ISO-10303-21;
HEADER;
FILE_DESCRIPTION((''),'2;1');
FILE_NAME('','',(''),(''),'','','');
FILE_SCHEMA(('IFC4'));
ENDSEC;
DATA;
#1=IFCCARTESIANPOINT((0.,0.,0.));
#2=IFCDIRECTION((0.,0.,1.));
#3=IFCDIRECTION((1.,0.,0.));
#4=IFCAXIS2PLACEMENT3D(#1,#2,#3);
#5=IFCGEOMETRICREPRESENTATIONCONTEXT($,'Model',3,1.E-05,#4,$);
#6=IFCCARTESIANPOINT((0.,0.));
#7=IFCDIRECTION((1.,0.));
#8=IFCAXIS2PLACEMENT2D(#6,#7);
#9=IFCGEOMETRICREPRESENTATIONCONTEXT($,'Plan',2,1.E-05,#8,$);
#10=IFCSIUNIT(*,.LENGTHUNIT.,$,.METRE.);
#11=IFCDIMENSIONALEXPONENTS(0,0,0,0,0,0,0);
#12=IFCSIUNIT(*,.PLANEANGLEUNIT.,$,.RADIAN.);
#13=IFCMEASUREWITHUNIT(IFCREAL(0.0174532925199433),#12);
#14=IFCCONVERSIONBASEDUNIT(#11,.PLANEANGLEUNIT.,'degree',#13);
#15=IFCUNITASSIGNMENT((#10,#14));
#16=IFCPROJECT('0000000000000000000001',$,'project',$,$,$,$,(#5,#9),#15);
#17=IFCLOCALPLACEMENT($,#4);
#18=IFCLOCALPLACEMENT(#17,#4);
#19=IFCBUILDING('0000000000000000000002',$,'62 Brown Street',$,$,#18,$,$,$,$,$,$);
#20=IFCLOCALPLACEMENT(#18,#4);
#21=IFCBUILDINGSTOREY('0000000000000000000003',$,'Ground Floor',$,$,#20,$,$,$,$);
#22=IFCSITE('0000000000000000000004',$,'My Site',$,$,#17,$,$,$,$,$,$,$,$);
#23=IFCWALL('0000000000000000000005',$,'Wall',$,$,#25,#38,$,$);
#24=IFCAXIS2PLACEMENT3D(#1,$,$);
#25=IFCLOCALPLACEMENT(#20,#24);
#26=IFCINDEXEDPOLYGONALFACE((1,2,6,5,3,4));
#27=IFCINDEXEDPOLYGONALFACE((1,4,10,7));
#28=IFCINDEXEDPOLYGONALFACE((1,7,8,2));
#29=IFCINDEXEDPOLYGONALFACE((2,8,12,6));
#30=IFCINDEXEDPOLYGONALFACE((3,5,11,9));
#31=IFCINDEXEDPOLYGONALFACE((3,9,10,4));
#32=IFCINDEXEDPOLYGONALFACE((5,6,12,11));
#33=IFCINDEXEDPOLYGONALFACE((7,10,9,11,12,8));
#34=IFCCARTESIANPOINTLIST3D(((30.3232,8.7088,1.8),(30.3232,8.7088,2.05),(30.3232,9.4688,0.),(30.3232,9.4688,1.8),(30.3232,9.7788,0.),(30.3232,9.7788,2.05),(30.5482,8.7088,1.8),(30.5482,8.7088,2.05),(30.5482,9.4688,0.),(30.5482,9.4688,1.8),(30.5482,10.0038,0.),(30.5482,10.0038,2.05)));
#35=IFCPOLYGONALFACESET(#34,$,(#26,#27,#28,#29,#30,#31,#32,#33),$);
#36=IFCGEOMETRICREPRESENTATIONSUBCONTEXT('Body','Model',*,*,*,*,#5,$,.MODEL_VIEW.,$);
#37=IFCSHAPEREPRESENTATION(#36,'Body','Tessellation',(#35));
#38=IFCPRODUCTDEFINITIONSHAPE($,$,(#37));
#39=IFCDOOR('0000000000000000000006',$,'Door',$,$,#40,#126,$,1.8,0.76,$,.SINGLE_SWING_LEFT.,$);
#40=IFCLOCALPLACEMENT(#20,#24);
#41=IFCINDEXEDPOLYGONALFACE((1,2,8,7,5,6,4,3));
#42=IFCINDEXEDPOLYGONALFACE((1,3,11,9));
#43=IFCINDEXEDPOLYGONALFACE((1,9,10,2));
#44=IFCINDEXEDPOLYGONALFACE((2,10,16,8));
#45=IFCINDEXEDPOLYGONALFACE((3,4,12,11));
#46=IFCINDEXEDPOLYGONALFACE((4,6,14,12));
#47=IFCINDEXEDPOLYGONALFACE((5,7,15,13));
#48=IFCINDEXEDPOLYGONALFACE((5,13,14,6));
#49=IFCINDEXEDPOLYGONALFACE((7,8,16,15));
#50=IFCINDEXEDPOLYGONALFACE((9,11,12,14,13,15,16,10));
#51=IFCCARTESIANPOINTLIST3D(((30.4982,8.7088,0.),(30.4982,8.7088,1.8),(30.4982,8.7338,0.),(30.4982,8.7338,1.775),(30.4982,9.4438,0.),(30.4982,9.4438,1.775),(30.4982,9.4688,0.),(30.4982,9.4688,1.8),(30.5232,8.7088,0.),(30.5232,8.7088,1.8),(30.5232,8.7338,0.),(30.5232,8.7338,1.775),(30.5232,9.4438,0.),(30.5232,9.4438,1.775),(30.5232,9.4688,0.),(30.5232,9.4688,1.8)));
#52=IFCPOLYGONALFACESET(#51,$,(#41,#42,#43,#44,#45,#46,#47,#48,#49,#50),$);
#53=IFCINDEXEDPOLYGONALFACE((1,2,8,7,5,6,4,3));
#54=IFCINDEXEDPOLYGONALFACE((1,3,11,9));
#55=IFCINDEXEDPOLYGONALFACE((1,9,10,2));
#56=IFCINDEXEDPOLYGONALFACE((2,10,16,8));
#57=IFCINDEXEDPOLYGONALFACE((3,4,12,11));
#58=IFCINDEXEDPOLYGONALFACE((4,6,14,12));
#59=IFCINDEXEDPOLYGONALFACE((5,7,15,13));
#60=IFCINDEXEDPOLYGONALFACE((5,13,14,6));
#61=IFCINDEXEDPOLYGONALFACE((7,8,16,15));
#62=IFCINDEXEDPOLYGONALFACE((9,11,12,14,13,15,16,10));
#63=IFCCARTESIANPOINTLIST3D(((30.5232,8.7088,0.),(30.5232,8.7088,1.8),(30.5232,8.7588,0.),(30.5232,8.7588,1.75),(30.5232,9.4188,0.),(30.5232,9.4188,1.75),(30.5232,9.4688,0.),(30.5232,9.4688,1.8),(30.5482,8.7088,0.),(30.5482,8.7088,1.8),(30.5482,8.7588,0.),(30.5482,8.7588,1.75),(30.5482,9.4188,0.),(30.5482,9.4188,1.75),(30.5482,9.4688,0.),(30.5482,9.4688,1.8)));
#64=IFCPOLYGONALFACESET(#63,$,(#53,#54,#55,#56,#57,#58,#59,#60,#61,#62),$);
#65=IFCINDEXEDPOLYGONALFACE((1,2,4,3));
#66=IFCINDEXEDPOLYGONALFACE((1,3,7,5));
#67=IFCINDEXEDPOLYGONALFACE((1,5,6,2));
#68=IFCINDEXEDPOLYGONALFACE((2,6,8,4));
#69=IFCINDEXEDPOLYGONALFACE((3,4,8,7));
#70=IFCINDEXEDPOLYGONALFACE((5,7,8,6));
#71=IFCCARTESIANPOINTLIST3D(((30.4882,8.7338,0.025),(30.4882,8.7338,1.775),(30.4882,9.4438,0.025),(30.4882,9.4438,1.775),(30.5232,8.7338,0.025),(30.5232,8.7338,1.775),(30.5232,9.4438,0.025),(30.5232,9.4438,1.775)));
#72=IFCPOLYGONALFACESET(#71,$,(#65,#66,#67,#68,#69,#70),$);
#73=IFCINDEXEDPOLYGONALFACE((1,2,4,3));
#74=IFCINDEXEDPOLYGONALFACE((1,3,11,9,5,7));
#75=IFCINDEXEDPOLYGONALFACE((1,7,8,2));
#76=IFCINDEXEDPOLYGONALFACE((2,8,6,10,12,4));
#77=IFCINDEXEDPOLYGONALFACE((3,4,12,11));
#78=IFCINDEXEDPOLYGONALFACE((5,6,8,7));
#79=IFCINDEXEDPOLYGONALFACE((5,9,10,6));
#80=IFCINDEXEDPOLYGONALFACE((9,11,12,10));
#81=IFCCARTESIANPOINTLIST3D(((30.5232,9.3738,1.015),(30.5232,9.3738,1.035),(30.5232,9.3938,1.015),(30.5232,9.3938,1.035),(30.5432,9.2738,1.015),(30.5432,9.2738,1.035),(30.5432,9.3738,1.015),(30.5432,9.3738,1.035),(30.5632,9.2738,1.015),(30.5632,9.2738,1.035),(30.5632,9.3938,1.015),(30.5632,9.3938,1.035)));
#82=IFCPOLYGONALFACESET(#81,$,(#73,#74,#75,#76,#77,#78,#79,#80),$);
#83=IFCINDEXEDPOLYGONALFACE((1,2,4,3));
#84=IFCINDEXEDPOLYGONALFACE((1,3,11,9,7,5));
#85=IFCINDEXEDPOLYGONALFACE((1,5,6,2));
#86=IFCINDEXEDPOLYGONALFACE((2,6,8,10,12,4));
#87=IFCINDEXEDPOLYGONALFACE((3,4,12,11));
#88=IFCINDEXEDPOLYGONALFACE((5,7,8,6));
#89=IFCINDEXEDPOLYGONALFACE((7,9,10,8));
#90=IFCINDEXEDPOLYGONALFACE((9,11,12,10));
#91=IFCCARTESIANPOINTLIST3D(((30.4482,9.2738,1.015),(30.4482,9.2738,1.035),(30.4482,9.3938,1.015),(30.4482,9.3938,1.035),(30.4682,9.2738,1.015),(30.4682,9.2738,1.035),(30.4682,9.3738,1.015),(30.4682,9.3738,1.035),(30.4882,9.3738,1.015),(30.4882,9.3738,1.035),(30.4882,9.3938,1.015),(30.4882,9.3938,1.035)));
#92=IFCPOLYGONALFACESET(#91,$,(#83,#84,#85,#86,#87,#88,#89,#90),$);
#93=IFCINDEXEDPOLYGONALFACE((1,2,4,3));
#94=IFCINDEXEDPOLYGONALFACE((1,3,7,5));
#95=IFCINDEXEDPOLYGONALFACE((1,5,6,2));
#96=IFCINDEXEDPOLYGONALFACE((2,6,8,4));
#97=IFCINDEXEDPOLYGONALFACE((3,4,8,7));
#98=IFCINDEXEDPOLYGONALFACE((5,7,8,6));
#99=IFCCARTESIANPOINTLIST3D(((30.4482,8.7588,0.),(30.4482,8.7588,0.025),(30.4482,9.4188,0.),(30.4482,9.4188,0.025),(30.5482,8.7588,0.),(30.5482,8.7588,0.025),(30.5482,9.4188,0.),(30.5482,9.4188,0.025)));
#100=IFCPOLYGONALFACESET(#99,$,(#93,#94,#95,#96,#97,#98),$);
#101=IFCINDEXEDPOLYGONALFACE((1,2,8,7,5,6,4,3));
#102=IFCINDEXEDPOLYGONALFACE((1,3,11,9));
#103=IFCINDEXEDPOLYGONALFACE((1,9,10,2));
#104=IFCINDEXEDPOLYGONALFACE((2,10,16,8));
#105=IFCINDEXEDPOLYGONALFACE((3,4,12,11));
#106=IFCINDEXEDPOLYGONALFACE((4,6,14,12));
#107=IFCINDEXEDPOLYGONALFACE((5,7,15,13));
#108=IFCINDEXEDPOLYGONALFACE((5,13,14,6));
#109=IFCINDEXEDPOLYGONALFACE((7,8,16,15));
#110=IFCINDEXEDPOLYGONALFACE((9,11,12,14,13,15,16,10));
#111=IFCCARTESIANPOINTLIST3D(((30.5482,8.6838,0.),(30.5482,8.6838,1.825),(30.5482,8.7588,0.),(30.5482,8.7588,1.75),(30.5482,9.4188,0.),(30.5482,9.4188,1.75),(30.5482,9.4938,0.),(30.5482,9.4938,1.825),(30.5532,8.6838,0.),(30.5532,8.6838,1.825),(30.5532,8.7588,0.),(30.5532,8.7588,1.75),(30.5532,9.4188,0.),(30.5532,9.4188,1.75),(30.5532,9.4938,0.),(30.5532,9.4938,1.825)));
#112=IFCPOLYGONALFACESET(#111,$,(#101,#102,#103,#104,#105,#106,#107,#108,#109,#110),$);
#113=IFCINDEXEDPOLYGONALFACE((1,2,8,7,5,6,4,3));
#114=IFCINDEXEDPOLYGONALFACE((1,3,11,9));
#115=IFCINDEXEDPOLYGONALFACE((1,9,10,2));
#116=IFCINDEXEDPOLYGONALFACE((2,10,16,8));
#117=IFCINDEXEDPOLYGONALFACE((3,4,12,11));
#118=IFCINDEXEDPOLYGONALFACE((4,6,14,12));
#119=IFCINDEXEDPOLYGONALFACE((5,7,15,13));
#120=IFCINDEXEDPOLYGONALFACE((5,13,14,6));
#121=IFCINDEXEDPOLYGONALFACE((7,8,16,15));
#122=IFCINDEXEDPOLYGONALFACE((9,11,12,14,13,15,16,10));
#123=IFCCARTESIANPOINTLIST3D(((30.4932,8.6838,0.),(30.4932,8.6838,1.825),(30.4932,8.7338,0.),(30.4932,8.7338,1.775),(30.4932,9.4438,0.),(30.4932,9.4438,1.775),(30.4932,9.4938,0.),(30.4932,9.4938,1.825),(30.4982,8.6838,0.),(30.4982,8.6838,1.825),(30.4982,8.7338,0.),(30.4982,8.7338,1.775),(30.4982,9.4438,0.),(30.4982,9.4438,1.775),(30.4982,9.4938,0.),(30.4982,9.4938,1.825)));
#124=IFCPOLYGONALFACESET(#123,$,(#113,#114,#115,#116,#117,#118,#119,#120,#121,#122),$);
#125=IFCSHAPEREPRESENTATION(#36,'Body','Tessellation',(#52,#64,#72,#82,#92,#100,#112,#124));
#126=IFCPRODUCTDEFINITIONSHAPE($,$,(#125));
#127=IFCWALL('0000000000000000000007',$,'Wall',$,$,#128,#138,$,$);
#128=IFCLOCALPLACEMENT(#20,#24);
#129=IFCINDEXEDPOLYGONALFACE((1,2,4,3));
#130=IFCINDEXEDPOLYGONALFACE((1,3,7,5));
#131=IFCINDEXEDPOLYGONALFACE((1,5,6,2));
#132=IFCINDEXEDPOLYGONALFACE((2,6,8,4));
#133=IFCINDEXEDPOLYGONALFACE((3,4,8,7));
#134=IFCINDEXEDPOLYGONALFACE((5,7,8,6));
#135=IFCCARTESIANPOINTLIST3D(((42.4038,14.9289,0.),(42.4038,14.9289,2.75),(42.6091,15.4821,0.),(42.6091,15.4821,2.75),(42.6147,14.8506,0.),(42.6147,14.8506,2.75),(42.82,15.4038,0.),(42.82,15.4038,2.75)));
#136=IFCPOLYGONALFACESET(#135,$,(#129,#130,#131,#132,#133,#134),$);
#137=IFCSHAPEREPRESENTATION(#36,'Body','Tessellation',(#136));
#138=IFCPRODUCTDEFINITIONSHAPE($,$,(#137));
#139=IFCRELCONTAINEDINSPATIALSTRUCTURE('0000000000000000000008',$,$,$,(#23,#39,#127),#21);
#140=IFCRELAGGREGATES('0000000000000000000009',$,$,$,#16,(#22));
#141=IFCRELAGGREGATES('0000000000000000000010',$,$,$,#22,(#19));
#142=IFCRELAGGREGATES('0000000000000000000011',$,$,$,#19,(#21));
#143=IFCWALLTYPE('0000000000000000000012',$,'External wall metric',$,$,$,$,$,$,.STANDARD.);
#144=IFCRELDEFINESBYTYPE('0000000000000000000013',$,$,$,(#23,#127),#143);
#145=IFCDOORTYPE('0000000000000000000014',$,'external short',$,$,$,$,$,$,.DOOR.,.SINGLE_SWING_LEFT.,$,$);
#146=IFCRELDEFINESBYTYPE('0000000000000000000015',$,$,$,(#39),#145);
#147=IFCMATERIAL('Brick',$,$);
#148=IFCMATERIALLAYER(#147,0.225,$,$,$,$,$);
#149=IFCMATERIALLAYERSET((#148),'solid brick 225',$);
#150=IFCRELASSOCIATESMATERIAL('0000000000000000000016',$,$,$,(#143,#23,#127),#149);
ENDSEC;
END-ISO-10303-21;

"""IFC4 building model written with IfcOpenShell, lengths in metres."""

from ifc_helpers import new_model, entity, si_unit, converted_unit, frame, origin_with_axes, origin_2d_with_axis, place, context, subcontext, project, spatial, line, indexed_curve, outline, extrude, clip, halfspace, shape, source, transform, mapped, material, layer, layer_set, layer_usage, type_object, type_shapes, element, fill, save


model = new_model("IFC4")

# Units and contexts
model_context = context("Model", 3, precision=1e-05, world=origin_with_axes())
plan_context = context("Plan", 2, precision=1e-05, world=origin_2d_with_axis())
body_context_1 = subcontext(model_context, "Body", "Model", "MODEL_VIEW")
body_context_2 = subcontext(plan_context, "Body", "Plan", "PLAN_VIEW")
ifc_project = project(units=[si_unit("LENGTHUNIT", "METRE"), converted_unit("PLANEANGLEUNIT", "degree", entity("IfcReal", 0.0174532925199433), si_unit("PLANEANGLEUNIT", "RADIAN"), dimensions=[0, 0, 0, 0, 0, 0, 0])], contexts=[model_context, plan_context])

# Site, building, storey
site_placement = place(None, origin_with_axes())
site = spatial("IfcSite", under=ifc_project, at=site_placement, Name="My Site")
building_placement = place(site_placement, origin_with_axes())
building = spatial("IfcBuilding", under=site, at=building_placement, Name="62 Brown Street")
storey_placement = place(building_placement, origin_with_axes())
storey = spatial("IfcBuildingStorey", under=building, at=storey_placement, Name="Ground Floor")

# Shared definitions
ifc_material_1 = material(Name="Brick")
ifc_layer_1 = layer(ifc_material_1, 0.225)
ifc_layer_set_1 = layer_set([ifc_layer_1], Name="solid brick 225")
wall_type_1 = type_object("IfcWallType", Name="External wall metric", PredefinedType="STANDARD", material=ifc_layer_set_1)

# Wall, opening, door
ifc_layer_usage_1 = layer_usage(ifc_layer_set_1, "AXIS2", "POSITIVE", 0.0)
wall_1_placement = place(storey_placement, frame((30.5482, 8.7088, 0.0), z_axis=(0.0, 0.0, 1.0), x_axis=(0.0, 1.0, 0.0)))
wall_1 = element("IfcWall", 1, at=wall_1_placement, inside=storey, type_object=wall_type_1, material=ifc_layer_usage_1, Name="Wall", context=body_context_1, shape_type="Clipping", body=[
    clip(extrude(outline(indexed_curve([(0.0, 0.0), (0.0, 0.225), (1.295, 0.225), (1.295, 0.0), (0.0, 0.0)], self_intersect=False)), origin_with_axes(), (0.0, 0.0, 1.0), 2.05), halfspace(frame((1.295, 0.0, 0.0), z_axis=(0.450001, 0.450001, 0.0), x_axis=(-0.225, 0.225, 0.0)), False)),
])
shared_shape_1 = source(origin_with_axes(), body_context_1, "Body", "SweptSolid", [
    extrude(outline(indexed_curve([(0.0, 0.0), (0.76, 0.0), (0.76, 1.8), (0.0, 1.8)], segments=[line(1, 2, 3, 4, 1)])), frame((0.0, -0.1, 0.0), z_axis=(0.0, -1.0, 0.0), x_axis=(1.0, 0.0, 0.0)), (0.0, 0.0, -1.0), 0.425),
])
opening_1_placement = place(wall_1_placement, frame((0.0, 0.0, 0.0), z_axis=(0.0, 0.0, 1.0), x_axis=(1.0, 0.0, 0.0)))
opening_1 = element("IfcOpeningElement", 2, at=opening_1_placement, cuts=wall_1, PredefinedType="OPENING", context=body_context_1, shape_type="MappedRepresentation", body=[
    mapped(shared_shape_1, transform((0.0, 0.0, 0.0), x_axis=(1.0, 0.0, 0.0), y_axis=(0.0, 1.0, 0.0), z_axis=(0.0, 0.0, 1.0), scale=1.0)),
])
door_type_1 = type_object("IfcDoorType", Name="external short", OperationType="SINGLE_SWING_LEFT", PredefinedType="DOOR")
shared_shape_2 = source(origin_with_axes(), body_context_1, "Body", "SweptSolid", [
    extrude(outline(indexed_curve([(0.0, 0.0), (0.0, 1.8), (0.76, 1.8), (0.76, 0.0), (0.735, 0.0), (0.735, 1.775), (0.025, 1.775), (0.025, 0.0)], segments=[line(1, 2, 3, 4, 5, 6, 7, 8, 1)])), frame((0.0, 0.025, 0.0), z_axis=(0.0, -1.0, 0.0), x_axis=(1.0, 0.0, 0.0)), (0.0, 0.0, -1.0), 0.025),
    extrude(outline(indexed_curve([(0.0, 0.0), (0.0, 1.8), (0.76, 1.8), (0.76, 0.0), (0.71, 0.0), (0.71, 1.75), (0.05, 1.75), (0.05, 0.0)], segments=[line(1, 2, 3, 4, 5, 6, 7, 8, 1)])), frame((0.0, 0.0, 0.0), z_axis=(0.0, -1.0, 0.0), x_axis=(1.0, 0.0, 0.0)), (0.0, 0.0, -1.0), 0.025),
    extrude(outline(indexed_curve([(0.0, 0.0), (0.71, 0.0), (0.71, 0.035), (0.0, 0.035)], segments=[line(1, 2, 3, 4, 1)])), frame((0.025, 0.025, 0.025), z_axis=(0.0, 0.0, 1.0), x_axis=(1.0, 0.0, 0.0)), (0.0, 0.0, 1.0), 1.75),
    extrude(outline(indexed_curve([(0.0, 0.0), (0.0, -0.04), (-0.12, -0.04), (-0.12, -0.02), (-0.02, -0.02), (-0.02, 0.0)], segments=[line(1, 2, 3, 4, 5, 6, 1)])), frame((0.685, 0.025, 1.015), z_axis=(0.0, 0.0, 1.0), x_axis=(1.0, 0.0, 0.0)), (0.0, 0.0, 1.0), 0.02),
    extrude(outline(indexed_curve([(0.0, 0.0), (0.0, 0.04), (-0.12, 0.04), (-0.12, 0.02), (-0.02, 0.02), (-0.02, 0.0)], segments=[line(1, 2, 3, 4, 5, 6, 1)])), frame((0.685, 0.06, 1.015), z_axis=(0.0, 0.0, 1.0), x_axis=(1.0, 0.0, 0.0)), (0.0, 0.0, 1.0), 0.02),
    extrude(outline(indexed_curve([(0.0, 0.0), (0.66, 0.0), (0.66, 0.1), (0.0, 0.1)], segments=[line(1, 2, 3, 4, 1)])), frame((0.05, 0.0, 0.0), z_axis=(0.0, 0.0, 1.0), x_axis=(1.0, 0.0, 0.0)), (0.0, 0.0, 1.0), 0.025),
    extrude(outline(indexed_curve([(0.0, 0.0), (0.0, 1.825), (0.81, 1.825), (0.81, 0.0), (0.735, 0.0), (0.735, 1.75), (0.075, 1.75), (0.075, 0.0)], segments=[line(1, 2, 3, 4, 5, 6, 7, 8, 1)])), frame((-0.025, -0.005, 0.0), z_axis=(0.0, -1.0, 0.0), x_axis=(1.0, 0.0, 0.0)), (0.0, 0.0, -1.0), 0.005),
    extrude(outline(indexed_curve([(0.0, 0.0), (0.0, 1.825), (0.81, 1.825), (0.81, 0.0), (0.76, 0.0), (0.76, 1.775), (0.05, 1.775), (0.05, 0.0)], segments=[line(1, 2, 3, 4, 5, 6, 7, 8, 1)])), frame((-0.025, 0.05, 0.0), z_axis=(0.0, -1.0, 0.0), x_axis=(1.0, 0.0, 0.0)), (0.0, 0.0, -1.0), 0.005),
])
shared_shape_3 = source(origin_with_axes(), body_context_2, "Body", "Curve2D", [
    entity("IfcIndexedPolyCurve", entity("IfcCartesianPointList2D", [[0.0, 0.0], [0.0, 0.05], [0.025, 0.05], [0.025, 0.025], [0.05, 0.025], [0.05, 0.0]]), [entity("IfcLineIndex", [1, 2, 3, 4, 5, 6, 1])]),
    entity("IfcIndexedPolyCurve", entity("IfcCartesianPointList2D", [[0.76, 0.0], [0.76, 0.05], [0.735, 0.05], [0.735, 0.025], [0.71, 0.025], [0.71, 0.0]]), [entity("IfcLineIndex", [1, 2, 3, 4, 5, 6, 1])]),
    entity("IfcTrimmedCurve", entity("IfcEllipse", entity("IfcAxis2Placement2D", entity("IfcCartesianPoint", [0.06, 0.05]), entity("IfcDirection", [1.0, 0.0])), 0.675, 0.71), [entity("IfcCartesianPoint", [0.735, 0.05])], [entity("IfcCartesianPoint", [0.06, 0.76])], True, "CARTESIAN"),
    entity("IfcIndexedPolyCurve", entity("IfcCartesianPointList2D", [[0.025, 0.05], [0.06, 0.05], [0.06, 0.76], [0.025, 0.76]]), [entity("IfcLineIndex", [1, 2, 3, 4, 1])]),
])
type_shapes(door_type_1, [shared_shape_2, shared_shape_3])
door_1_placement = place(opening_1_placement, frame((0.0, 0.0, 0.0), z_axis=(0.0, 0.0, 1.0), x_axis=(1.0, 0.0, 0.0)))
door_1 = element("IfcDoor", 3, at=door_1_placement, inside=storey, type_object=door_type_1, Name="Door", OperationType="SINGLE_SWING_LEFT", OverallHeight=1.8, OverallWidth=0.76, shapes=[
    shape(body_context_1, "Body", "MappedRepresentation", [mapped(shared_shape_2, transform((0.0, 0.0, 0.0), x_axis=(1.0, 0.0, 0.0), y_axis=(0.0, 1.0, 0.0), z_axis=(0.0, 0.0, 1.0), scale=1.0))]),
    shape(body_context_2, "Body", "MappedRepresentation", [mapped(shared_shape_3, transform((0.0, 0.0, 0.0), x_axis=(1.0, 0.0, 0.0), y_axis=(0.0, 1.0, 0.0), z_axis=(0.0, 0.0, 1.0), scale=1.0))]),
])
fill(opening_1, door_1)

# Wall
ifc_layer_usage_2 = layer_usage(ifc_layer_set_1, "AXIS2", "POSITIVE", 0.0)
wall_2_placement = place(storey_placement, frame((42.6147, 14.8506, 0.0), z_axis=(0.0, 0.0, 1.0), x_axis=(0.347944, 0.937515, 0.0)))
element("IfcWall", 4, at=wall_2_placement, inside=storey, type_object=wall_type_1, material=ifc_layer_usage_2, Name="Wall", context=body_context_1, shape_type="SweptSolid", body=[
    extrude(outline(indexed_curve([(0.0, 0.0), (0.0, 0.225), (0.5901, 0.225), (0.5901, 0.0), (0.0, 0.0)], self_intersect=False)), origin_with_axes(), (0.0, 0.0, 1.0), 2.75),
])

save(model, "model.ifc")
